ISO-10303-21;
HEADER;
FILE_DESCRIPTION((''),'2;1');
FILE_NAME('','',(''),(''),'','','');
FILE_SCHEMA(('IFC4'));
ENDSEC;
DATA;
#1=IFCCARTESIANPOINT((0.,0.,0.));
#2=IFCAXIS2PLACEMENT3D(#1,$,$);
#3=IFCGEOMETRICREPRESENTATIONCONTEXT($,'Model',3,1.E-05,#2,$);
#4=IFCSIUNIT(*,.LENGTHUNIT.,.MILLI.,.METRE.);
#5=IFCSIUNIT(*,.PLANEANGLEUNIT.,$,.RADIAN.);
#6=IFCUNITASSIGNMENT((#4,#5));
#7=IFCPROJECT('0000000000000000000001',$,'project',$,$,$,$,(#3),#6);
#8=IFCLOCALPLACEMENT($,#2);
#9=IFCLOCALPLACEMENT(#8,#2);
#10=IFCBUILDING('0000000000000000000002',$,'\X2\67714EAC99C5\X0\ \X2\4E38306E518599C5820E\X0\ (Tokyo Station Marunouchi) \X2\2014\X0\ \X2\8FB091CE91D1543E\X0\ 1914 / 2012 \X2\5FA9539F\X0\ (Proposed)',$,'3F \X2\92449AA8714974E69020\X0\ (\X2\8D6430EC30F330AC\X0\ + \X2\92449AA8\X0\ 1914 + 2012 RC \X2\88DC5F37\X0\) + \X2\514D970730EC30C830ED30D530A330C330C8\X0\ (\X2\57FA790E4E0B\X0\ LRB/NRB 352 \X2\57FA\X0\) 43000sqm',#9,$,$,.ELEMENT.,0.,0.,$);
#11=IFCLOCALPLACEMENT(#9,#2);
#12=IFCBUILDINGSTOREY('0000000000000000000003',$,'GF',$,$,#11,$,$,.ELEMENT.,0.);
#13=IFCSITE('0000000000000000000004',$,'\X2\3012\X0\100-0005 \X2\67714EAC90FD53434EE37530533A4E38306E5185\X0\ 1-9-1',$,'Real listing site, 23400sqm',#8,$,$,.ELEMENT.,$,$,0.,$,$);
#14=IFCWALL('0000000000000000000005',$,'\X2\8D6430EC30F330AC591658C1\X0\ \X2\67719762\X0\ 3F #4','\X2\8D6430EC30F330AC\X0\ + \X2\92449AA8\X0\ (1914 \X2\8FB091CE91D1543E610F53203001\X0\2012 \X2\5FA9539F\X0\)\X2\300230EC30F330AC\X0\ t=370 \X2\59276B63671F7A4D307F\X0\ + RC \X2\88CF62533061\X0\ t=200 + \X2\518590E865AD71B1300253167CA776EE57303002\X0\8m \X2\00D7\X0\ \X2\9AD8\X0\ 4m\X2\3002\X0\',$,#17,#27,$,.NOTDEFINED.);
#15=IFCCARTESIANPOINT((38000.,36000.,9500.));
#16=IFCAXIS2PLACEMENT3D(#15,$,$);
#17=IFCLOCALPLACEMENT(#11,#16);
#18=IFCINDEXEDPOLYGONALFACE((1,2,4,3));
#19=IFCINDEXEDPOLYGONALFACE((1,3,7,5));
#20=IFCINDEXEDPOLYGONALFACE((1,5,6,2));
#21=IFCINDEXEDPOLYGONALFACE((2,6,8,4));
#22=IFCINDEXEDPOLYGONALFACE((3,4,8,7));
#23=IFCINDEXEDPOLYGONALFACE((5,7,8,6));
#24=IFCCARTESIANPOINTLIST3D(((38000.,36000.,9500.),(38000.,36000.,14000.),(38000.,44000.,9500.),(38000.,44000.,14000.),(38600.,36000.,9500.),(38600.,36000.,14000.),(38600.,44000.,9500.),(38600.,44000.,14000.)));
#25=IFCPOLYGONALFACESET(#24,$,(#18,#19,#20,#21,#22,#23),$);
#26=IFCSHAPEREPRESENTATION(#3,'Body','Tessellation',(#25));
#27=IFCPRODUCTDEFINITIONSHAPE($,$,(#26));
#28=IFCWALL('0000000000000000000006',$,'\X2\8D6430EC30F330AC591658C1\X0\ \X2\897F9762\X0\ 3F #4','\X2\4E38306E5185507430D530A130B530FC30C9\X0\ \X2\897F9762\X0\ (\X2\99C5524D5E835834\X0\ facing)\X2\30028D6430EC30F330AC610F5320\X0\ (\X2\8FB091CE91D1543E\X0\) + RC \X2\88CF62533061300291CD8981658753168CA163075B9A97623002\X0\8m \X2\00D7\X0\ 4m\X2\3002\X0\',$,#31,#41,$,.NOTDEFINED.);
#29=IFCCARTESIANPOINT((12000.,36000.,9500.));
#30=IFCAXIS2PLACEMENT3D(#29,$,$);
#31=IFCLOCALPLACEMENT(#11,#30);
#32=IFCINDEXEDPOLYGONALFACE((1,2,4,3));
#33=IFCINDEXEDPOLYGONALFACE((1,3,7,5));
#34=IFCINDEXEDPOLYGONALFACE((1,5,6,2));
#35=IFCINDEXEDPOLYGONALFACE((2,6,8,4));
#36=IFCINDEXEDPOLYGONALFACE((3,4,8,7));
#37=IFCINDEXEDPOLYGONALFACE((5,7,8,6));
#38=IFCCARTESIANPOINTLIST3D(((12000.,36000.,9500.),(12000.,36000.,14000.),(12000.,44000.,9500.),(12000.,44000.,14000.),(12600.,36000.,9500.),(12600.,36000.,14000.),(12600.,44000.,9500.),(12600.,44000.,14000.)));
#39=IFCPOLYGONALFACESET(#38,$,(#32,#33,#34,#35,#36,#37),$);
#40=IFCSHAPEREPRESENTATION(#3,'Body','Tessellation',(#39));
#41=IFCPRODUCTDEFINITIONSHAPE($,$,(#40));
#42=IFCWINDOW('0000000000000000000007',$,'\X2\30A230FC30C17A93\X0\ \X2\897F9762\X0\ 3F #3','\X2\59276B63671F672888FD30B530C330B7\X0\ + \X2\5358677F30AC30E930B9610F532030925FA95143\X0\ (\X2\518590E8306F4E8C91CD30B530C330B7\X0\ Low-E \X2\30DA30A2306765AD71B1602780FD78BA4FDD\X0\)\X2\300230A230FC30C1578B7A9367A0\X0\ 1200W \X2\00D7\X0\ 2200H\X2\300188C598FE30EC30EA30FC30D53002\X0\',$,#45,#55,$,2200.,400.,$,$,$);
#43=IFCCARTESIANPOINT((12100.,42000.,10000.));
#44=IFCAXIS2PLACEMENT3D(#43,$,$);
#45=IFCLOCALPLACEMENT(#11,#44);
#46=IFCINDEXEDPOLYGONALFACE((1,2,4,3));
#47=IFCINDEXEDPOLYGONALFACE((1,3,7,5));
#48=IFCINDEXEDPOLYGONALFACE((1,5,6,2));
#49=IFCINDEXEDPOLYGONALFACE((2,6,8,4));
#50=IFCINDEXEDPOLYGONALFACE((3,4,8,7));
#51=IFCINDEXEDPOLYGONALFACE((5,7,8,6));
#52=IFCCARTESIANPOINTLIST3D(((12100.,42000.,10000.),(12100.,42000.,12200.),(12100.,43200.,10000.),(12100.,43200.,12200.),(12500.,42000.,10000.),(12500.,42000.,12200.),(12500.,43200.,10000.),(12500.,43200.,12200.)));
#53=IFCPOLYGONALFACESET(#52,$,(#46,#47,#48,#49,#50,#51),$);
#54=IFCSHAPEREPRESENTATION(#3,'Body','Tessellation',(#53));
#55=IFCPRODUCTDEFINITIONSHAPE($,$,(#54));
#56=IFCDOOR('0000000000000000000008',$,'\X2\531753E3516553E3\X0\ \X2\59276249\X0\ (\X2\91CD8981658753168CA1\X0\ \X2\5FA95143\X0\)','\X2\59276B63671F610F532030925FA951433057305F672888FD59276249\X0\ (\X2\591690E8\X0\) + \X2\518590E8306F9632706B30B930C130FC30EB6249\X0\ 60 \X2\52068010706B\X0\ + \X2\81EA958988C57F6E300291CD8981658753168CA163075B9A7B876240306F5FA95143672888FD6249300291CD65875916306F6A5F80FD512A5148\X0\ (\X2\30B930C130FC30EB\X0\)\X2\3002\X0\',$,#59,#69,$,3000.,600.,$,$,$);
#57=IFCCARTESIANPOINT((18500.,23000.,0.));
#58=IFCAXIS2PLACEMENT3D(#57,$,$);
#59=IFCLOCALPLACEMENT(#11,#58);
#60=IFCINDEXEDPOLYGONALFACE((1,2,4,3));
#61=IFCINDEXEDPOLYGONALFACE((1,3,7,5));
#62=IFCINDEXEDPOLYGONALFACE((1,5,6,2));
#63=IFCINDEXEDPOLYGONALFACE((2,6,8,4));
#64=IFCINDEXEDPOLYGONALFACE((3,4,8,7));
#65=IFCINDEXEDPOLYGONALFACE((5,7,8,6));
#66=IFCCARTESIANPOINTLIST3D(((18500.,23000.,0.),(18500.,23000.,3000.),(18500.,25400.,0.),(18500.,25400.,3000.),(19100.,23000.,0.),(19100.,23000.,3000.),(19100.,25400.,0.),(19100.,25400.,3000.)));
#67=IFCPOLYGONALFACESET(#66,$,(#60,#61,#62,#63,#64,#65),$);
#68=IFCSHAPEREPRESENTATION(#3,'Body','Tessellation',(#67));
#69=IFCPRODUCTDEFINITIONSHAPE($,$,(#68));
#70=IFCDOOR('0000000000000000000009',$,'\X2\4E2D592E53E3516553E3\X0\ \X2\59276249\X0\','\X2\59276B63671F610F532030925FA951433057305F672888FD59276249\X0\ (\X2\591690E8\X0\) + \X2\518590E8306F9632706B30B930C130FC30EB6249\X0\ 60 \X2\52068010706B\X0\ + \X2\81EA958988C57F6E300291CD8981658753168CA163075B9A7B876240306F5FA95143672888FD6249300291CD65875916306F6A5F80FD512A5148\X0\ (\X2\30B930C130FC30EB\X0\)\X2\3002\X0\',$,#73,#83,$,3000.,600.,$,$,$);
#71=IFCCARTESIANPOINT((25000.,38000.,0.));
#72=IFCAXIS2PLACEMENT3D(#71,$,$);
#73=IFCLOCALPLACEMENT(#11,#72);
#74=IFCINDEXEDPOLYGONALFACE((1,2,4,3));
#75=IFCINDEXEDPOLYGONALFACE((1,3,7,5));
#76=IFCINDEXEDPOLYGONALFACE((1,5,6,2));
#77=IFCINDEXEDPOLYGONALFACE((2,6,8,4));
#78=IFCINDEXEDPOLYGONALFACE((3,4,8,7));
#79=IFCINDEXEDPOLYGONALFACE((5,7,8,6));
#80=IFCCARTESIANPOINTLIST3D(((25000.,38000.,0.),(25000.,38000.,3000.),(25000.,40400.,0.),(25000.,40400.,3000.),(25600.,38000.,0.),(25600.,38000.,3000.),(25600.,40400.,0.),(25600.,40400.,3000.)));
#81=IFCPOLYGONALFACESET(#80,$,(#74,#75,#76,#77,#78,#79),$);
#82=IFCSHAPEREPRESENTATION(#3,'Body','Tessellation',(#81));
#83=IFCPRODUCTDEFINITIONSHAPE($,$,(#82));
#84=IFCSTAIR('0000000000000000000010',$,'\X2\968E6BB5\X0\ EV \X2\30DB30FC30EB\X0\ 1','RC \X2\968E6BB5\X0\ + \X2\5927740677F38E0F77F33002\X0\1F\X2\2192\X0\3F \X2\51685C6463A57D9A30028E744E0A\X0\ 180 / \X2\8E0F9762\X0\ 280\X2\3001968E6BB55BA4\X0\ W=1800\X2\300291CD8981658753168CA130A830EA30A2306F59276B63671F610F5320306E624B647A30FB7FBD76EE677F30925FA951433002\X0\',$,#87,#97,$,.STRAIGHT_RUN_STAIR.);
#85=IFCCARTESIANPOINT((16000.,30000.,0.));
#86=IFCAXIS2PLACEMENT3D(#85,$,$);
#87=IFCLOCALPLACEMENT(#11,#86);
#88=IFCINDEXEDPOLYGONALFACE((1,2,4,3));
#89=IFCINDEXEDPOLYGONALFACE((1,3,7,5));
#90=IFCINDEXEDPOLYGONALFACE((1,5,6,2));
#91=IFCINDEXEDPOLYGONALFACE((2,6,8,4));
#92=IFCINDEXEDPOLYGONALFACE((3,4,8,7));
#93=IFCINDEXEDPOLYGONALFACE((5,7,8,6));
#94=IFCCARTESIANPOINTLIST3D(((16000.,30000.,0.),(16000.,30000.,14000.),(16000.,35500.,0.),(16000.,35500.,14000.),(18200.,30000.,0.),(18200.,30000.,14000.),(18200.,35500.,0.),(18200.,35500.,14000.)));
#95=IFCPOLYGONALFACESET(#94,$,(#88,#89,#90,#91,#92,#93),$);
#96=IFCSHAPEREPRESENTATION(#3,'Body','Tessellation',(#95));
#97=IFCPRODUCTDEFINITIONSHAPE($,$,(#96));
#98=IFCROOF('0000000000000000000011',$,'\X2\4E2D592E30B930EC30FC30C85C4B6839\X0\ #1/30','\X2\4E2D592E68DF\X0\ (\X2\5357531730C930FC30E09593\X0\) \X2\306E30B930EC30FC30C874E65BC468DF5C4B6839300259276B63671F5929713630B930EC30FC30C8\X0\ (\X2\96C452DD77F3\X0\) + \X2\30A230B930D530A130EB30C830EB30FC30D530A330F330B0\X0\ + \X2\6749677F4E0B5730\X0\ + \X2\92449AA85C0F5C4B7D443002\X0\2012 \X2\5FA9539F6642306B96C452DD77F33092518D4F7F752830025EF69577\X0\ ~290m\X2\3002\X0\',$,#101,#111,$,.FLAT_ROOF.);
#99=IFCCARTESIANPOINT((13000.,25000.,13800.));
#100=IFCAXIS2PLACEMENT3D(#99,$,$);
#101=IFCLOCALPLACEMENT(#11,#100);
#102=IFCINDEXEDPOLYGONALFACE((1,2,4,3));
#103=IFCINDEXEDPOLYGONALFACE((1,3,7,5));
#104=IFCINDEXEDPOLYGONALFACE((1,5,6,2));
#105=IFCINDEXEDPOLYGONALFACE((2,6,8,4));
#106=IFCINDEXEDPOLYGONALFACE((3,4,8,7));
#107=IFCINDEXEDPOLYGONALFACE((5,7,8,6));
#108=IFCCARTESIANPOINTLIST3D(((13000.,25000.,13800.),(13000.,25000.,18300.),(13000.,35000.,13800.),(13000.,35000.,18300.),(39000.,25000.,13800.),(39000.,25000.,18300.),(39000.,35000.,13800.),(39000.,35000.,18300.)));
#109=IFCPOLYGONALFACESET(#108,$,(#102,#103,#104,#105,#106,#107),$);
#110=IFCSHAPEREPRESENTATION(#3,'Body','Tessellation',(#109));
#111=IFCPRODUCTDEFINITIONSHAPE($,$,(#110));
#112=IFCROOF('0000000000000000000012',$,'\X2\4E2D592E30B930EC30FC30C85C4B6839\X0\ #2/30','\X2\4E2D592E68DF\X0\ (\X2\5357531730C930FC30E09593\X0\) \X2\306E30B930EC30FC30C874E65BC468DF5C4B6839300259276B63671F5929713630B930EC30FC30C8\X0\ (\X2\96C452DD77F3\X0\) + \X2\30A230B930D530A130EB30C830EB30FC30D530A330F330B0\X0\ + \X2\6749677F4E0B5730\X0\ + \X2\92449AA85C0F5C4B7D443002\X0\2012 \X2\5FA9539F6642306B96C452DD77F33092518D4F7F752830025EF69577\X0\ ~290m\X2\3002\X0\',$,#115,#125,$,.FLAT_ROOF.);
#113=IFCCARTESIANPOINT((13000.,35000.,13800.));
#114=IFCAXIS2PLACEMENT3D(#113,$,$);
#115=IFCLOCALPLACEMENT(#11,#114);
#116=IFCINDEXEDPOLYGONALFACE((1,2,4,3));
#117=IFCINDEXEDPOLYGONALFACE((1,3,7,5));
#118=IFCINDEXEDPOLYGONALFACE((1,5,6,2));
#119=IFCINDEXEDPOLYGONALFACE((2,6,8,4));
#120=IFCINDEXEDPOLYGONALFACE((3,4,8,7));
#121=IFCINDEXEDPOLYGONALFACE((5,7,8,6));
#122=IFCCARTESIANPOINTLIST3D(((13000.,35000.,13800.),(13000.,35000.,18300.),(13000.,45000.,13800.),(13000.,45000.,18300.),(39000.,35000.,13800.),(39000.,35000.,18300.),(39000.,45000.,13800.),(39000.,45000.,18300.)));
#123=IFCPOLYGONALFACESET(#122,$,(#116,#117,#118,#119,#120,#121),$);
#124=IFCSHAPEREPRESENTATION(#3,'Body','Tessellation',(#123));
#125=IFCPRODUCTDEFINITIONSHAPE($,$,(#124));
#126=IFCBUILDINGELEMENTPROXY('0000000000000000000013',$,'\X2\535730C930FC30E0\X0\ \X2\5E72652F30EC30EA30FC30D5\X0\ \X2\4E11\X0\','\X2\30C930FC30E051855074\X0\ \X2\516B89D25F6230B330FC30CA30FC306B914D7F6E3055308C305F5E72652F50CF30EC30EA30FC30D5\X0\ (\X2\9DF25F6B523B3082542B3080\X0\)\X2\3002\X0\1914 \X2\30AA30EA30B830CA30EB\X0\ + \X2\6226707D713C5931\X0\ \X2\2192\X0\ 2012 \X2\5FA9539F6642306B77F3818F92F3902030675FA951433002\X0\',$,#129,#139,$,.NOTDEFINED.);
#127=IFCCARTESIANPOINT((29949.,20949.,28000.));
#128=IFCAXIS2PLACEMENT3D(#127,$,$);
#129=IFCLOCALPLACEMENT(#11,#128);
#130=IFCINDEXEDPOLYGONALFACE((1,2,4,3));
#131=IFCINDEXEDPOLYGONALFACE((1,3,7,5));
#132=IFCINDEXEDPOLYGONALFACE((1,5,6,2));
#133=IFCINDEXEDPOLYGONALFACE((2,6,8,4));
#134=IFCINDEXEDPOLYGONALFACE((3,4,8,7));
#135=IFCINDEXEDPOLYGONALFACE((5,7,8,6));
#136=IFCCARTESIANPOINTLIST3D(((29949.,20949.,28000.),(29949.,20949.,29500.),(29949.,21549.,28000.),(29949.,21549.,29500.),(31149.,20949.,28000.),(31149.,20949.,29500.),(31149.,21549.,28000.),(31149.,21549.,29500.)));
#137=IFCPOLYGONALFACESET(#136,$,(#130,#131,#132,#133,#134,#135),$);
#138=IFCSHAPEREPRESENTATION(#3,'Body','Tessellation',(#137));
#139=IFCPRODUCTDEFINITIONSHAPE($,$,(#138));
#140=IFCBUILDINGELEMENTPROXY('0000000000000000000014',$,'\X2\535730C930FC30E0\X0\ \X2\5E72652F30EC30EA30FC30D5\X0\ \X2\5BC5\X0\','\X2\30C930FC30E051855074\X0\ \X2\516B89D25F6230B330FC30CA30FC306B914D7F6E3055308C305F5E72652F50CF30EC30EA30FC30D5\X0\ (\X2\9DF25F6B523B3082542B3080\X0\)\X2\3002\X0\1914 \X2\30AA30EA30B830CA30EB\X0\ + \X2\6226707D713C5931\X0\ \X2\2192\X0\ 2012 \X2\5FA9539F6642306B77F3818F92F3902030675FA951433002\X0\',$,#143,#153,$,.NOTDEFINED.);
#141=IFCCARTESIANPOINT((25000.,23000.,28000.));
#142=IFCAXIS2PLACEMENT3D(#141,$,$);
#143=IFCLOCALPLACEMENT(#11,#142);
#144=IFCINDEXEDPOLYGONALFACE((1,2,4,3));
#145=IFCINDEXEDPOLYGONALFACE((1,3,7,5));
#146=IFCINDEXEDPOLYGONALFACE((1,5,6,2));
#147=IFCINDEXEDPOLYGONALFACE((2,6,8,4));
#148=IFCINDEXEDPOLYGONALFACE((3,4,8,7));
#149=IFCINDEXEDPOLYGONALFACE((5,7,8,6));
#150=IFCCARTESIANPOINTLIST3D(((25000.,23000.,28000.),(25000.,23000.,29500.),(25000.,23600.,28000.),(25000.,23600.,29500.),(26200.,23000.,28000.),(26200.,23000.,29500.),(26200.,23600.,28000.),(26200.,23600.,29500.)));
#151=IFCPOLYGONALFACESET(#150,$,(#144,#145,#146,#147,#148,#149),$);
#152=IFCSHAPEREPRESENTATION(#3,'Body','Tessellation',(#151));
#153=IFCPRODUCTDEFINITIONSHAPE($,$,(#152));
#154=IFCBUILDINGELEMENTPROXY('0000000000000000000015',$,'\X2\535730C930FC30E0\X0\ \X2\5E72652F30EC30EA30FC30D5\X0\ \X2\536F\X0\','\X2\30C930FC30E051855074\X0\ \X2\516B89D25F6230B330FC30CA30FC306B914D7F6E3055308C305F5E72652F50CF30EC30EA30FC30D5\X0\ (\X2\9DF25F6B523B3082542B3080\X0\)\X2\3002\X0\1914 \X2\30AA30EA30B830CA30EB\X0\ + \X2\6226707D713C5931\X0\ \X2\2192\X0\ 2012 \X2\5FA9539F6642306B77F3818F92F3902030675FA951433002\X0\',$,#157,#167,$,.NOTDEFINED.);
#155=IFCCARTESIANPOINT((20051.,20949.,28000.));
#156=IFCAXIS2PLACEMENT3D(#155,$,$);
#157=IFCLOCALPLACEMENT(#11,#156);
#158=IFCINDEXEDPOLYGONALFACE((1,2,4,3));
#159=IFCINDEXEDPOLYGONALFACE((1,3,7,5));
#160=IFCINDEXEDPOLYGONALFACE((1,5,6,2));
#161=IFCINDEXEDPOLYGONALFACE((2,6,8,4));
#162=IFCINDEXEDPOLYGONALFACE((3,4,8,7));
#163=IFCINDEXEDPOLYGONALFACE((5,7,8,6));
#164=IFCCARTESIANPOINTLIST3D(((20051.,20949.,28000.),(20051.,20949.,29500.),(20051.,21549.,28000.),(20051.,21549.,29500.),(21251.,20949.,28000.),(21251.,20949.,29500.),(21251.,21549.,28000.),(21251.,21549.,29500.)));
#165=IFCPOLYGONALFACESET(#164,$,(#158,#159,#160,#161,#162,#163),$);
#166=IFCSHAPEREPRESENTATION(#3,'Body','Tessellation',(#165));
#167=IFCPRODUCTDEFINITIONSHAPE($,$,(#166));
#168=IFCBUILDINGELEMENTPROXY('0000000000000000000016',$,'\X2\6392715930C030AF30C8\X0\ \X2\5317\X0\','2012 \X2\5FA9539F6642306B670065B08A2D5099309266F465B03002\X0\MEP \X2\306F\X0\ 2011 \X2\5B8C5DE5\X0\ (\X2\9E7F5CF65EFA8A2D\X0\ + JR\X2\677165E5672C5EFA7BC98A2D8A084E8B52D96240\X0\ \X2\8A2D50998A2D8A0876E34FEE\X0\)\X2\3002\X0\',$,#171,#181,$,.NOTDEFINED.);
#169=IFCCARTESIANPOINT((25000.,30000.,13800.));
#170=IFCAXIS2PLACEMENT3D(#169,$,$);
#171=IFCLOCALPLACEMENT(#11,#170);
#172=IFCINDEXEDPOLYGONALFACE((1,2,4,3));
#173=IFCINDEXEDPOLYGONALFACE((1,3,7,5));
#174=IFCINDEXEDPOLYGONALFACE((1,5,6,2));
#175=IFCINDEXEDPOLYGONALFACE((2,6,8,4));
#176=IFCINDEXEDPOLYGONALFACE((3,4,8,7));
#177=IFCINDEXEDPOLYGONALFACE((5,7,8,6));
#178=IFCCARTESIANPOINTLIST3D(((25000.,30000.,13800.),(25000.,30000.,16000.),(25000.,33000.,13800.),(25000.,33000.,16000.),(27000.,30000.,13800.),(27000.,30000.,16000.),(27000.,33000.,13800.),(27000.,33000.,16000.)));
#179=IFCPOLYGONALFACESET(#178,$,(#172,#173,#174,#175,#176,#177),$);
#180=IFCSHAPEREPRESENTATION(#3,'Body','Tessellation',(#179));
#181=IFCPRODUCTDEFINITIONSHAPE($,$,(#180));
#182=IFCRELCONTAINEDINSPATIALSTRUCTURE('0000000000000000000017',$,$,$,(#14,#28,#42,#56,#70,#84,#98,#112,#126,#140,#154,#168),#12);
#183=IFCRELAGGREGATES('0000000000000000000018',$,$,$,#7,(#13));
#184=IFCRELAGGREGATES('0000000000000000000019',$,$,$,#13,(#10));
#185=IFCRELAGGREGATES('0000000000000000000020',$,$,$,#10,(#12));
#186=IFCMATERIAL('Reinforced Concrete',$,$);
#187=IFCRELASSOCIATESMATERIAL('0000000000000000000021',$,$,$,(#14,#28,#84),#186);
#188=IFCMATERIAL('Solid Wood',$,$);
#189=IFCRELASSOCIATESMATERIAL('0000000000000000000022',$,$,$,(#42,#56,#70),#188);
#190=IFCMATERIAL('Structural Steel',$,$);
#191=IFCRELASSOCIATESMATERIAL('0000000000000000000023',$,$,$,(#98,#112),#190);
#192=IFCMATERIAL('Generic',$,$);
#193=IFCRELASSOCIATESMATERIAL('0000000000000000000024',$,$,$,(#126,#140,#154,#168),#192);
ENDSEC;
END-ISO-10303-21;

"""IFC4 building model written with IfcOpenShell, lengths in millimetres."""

from ifc_helpers import new_model, si_unit, frame, frame_2d, origin, place, context, project, spatial, rectangle, extrude, material, element, fill, save


model = new_model("IFC4")

# Units and contexts
model_context = context("Model", 3, precision=1e-05, world=origin())
ifc_project = project(units=[si_unit("LENGTHUNIT", "METRE", prefix="MILLI"), si_unit("PLANEANGLEUNIT", "RADIAN")], contexts=[model_context])

# Site, building, storey
site_placement = place(None, origin())
site = spatial("IfcSite", under=ifc_project, at=site_placement, Name="〒100-0005 東京都千代田区丸の内 1-9-1", ObjectType="Real listing site, 23400sqm", CompositionType="ELEMENT", RefElevation=0.0)
building_placement = place(site_placement, origin())
building = spatial("IfcBuilding", under=site, at=building_placement, Name="東京駅 丸の内駅舎 (Tokyo Station Marunouchi) — 辰野金吾 1914 / 2012 復原 (Proposed)", ObjectType="3F 鉄骨煉瓦造 (赤レンガ + 鉄骨 1914 + 2012 RC 補強) + 免震レトロフィット (基礎下 LRB/NRB 352 基) 43000sqm", CompositionType="ELEMENT", ElevationOfRefHeight=0.0, ElevationOfTerrain=0.0)
storey_placement = place(building_placement, origin())
storey = spatial("IfcBuildingStorey", under=building, at=storey_placement, Name="GF", CompositionType="ELEMENT", Elevation=0.0)

# Shared definitions
ifc_material_1 = material(Name="Structural Steel")

# Shared definitions
ifc_material_2 = material(Name="Reinforced Concrete")

# Shared definitions
ifc_material_3 = material(Name="Solid Wood")

# Wall
wall_1_placement = place(storey_placement, frame((38000.0, 36000.0, 9500.0)))
element("IfcWall", 1, at=wall_1_placement, inside=storey, material=ifc_material_2, Name="赤レンガ外壁 東面 3F #4", Description="赤レンガ + 鉄骨 (1914 辰野金吾意匠、2012 復原)。レンガ t=370 大正期積み + RC 裏打ち t=200 + 内部断熱。化粧目地。8m × 高 4m。", PredefinedType="NOTDEFINED", context=model_context, shape_type="SweptSolid", body=[
    extrude(rectangle(XDim=600.0, YDim=8000.0, at=frame_2d((300.0, 4000.0))), frame((38000.0, 36000.0, 9500.0)), (0.0, 0.0, 1.0), 4500.0),
])

# Wall, opening, window
wall_2_placement = place(storey_placement, frame((12000.0, 36000.0, 9500.0)))
wall_2 = element("IfcWall", 2, at=wall_2_placement, inside=storey, material=ifc_material_2, Name="赤レンガ外壁 西面 3F #4", Description="丸の内側ファサード 西面 (駅前広場 facing)。赤レンガ意匠 (辰野金吾) + RC 裏打ち。重要文化財指定面。8m × 4m。", PredefinedType="NOTDEFINED", context=model_context, shape_type="SweptSolid", body=[
    extrude(rectangle(XDim=600.0, YDim=8000.0, at=frame_2d((300.0, 4000.0))), frame((12000.0, 36000.0, 9500.0)), (0.0, 0.0, 1.0), 4500.0),
])
opening_1_placement = place(storey_placement, frame((12100.0, 42000.0, 10000.0)))
opening_1 = element("IfcOpeningElement", 3, at=opening_1_placement, cuts=wall_2, PredefinedType="NOTDEFINED", context=model_context, shape_type="SweptSolid", body=[
    extrude(rectangle(XDim=400.0, YDim=1200.0, at=frame_2d((200.0, 600.0))), frame((12100.0, 42000.0, 10000.0)), (0.0, 0.0, 1.0), 2200.0),
])
window_1_placement = place(storey_placement, frame((12100.0, 42000.0, 10000.0)))
window_1 = element("IfcWindow", 4, at=window_1_placement, inside=storey, material=ifc_material_3, Name="アーチ窓 西面 3F #3", Description="大正期木製サッシ + 単板ガラス意匠を復元 (内部は二重サッシ Low-E ペアで断熱性能確保)。アーチ型窓枠 1200W × 2200H、装飾レリーフ。", OverallHeight=2200.0, OverallWidth=400.0, context=model_context, shape_type="SweptSolid", body=[
    extrude(rectangle(XDim=400.0, YDim=1200.0, at=frame_2d((200.0, 600.0))), frame((12100.0, 42000.0, 10000.0)), (0.0, 0.0, 1.0), 2200.0),
])
fill(opening_1, window_1)

# Doors
door_1_placement = place(storey_placement, frame((18500.0, 23000.0, 0.0)))
element("IfcDoor", 5, at=door_1_placement, inside=storey, material=ifc_material_3, Name="北口入口 大扉 (重要文化財 復元)", Description="大正期意匠を復元した木製大扉 (外部) + 内部は防火スチール扉 60 分耐火 + 自閉装置。重要文化財指定箇所は復元木製扉。重文外は機能優先 (スチール)。", OverallHeight=3000.0, OverallWidth=600.0, context=model_context, shape_type="SweptSolid", body=[
    extrude(rectangle(XDim=600.0, YDim=2400.0, at=frame_2d((300.0, 1200.0))), frame((18500.0, 23000.0, 0.0)), (0.0, 0.0, 1.0), 3000.0),
])
door_2_placement = place(storey_placement, frame((25000.0, 38000.0, 0.0)))
element("IfcDoor", 6, at=door_2_placement, inside=storey, material=ifc_material_3, Name="中央口入口 大扉", Description="大正期意匠を復元した木製大扉 (外部) + 内部は防火スチール扉 60 分耐火 + 自閉装置。重要文化財指定箇所は復元木製扉。重文外は機能優先 (スチール)。", OverallHeight=3000.0, OverallWidth=600.0, context=model_context, shape_type="SweptSolid", body=[
    extrude(rectangle(XDim=600.0, YDim=2400.0, at=frame_2d((300.0, 1200.0))), frame((25000.0, 38000.0, 0.0)), (0.0, 0.0, 1.0), 3000.0),
])

# Stair
stair_placement = place(storey_placement, frame((16000.0, 30000.0, 0.0)))
element("IfcStair", 7, at=stair_placement, inside=storey, material=ifc_material_2, Name="階段 EV ホール 1", Description="RC 階段 + 大理石踏石。1F→3F 全層接続。蹴上 180 / 踏面 280、階段室 W=1800。重要文化財エリアは大正期意匠の手摺・羽目板を復元。", PredefinedType="STRAIGHT_RUN_STAIR", context=model_context, shape_type="SweptSolid", body=[
    extrude(rectangle(XDim=2200.0, YDim=5500.0, at=frame_2d((1100.0, 2750.0))), frame((16000.0, 30000.0, 0.0)), (0.0, 0.0, 1.0), 14000.0),
])

# Roofs
roof_1_placement = place(storey_placement, frame((13000.0, 25000.0, 13800.0)))
element("IfcRoof", 8, at=roof_1_placement, inside=storey, material=ifc_material_1, Name="中央スレート屋根 #1/30", Description="中央棟 (南北ドーム間) のスレート瓦寄棟屋根。大正期天然スレート (雄勝石) + アスファルトルーフィング + 杉板下地 + 鉄骨小屋組。2012 復原時に雄勝石を再使用。延長 ~290m。", PredefinedType="FLAT_ROOF", context=model_context, shape_type="SweptSolid", body=[
    extrude(rectangle(XDim=26000.0, YDim=10000.0, at=frame_2d((13000.0, 5000.0))), frame((13000.0, 25000.0, 13800.0)), (0.0, 0.0, 1.0), 4500.0),
])
roof_2_placement = place(storey_placement, frame((13000.0, 35000.0, 13800.0)))
element("IfcRoof", 9, at=roof_2_placement, inside=storey, material=ifc_material_1, Name="中央スレート屋根 #2/30", Description="中央棟 (南北ドーム間) のスレート瓦寄棟屋根。大正期天然スレート (雄勝石) + アスファルトルーフィング + 杉板下地 + 鉄骨小屋組。2012 復原時に雄勝石を再使用。延長 ~290m。", PredefinedType="FLAT_ROOF", context=model_context, shape_type="SweptSolid", body=[
    extrude(rectangle(XDim=26000.0, YDim=10000.0, at=frame_2d((13000.0, 5000.0))), frame((13000.0, 35000.0, 13800.0)), (0.0, 0.0, 1.0), 4500.0),
])

# Building element proxies
ifc_material_4 = material(Name="Generic")
proxy_1_placement = place(storey_placement, frame((29949.0, 20949.0, 28000.0)))
element("IfcBuildingElementProxy", 10, at=proxy_1_placement, inside=storey, material=ifc_material_4, Name="南ドーム 干支レリーフ 丑", Description="ドーム内側 八角形コーナーに配置された干支像レリーフ (鷲彫刻も含む)。1914 オリジナル + 戦災焼失 → 2012 復原時に石膏鋳造で復元。", PredefinedType="NOTDEFINED", context=model_context, shape_type="SweptSolid", body=[
    extrude(rectangle(XDim=1200.0, YDim=600.0, at=frame_2d((600.0, 300.0))), frame((29949.0, 20949.0, 28000.0)), (0.0, 0.0, 1.0), 1500.0),
])
proxy_2_placement = place(storey_placement, frame((25000.0, 23000.0, 28000.0)))
element("IfcBuildingElementProxy", 11, at=proxy_2_placement, inside=storey, material=ifc_material_4, Name="南ドーム 干支レリーフ 寅", Description="ドーム内側 八角形コーナーに配置された干支像レリーフ (鷲彫刻も含む)。1914 オリジナル + 戦災焼失 → 2012 復原時に石膏鋳造で復元。", PredefinedType="NOTDEFINED", context=model_context, shape_type="SweptSolid", body=[
    extrude(rectangle(XDim=1200.0, YDim=600.0, at=frame_2d((600.0, 300.0))), frame((25000.0, 23000.0, 28000.0)), (0.0, 0.0, 1.0), 1500.0),
])
proxy_3_placement = place(storey_placement, frame((20051.0, 20949.0, 28000.0)))
element("IfcBuildingElementProxy", 12, at=proxy_3_placement, inside=storey, material=ifc_material_4, Name="南ドーム 干支レリーフ 卯", Description="ドーム内側 八角形コーナーに配置された干支像レリーフ (鷲彫刻も含む)。1914 オリジナル + 戦災焼失 → 2012 復原時に石膏鋳造で復元。", PredefinedType="NOTDEFINED", context=model_context, shape_type="SweptSolid", body=[
    extrude(rectangle(XDim=1200.0, YDim=600.0, at=frame_2d((600.0, 300.0))), frame((20051.0, 20949.0, 28000.0)), (0.0, 0.0, 1.0), 1500.0),
])
proxy_4_placement = place(storey_placement, frame((25000.0, 30000.0, 13800.0)))
element("IfcBuildingElementProxy", 13, at=proxy_4_placement, inside=storey, material=ifc_material_4, Name="排煙ダクト 北", Description="2012 復原時に最新設備を更新。MEP は 2011 完工 (鹿島建設 + JR東日本建築設計事務所 設備設計監修)。", PredefinedType="NOTDEFINED", context=model_context, shape_type="SweptSolid", body=[
    extrude(rectangle(XDim=2000.0, YDim=3000.0, at=frame_2d((1000.0, 1500.0))), frame((25000.0, 30000.0, 13800.0)), (0.0, 0.0, 1.0), 2200.0),
])

save(model, "model.ifc")
